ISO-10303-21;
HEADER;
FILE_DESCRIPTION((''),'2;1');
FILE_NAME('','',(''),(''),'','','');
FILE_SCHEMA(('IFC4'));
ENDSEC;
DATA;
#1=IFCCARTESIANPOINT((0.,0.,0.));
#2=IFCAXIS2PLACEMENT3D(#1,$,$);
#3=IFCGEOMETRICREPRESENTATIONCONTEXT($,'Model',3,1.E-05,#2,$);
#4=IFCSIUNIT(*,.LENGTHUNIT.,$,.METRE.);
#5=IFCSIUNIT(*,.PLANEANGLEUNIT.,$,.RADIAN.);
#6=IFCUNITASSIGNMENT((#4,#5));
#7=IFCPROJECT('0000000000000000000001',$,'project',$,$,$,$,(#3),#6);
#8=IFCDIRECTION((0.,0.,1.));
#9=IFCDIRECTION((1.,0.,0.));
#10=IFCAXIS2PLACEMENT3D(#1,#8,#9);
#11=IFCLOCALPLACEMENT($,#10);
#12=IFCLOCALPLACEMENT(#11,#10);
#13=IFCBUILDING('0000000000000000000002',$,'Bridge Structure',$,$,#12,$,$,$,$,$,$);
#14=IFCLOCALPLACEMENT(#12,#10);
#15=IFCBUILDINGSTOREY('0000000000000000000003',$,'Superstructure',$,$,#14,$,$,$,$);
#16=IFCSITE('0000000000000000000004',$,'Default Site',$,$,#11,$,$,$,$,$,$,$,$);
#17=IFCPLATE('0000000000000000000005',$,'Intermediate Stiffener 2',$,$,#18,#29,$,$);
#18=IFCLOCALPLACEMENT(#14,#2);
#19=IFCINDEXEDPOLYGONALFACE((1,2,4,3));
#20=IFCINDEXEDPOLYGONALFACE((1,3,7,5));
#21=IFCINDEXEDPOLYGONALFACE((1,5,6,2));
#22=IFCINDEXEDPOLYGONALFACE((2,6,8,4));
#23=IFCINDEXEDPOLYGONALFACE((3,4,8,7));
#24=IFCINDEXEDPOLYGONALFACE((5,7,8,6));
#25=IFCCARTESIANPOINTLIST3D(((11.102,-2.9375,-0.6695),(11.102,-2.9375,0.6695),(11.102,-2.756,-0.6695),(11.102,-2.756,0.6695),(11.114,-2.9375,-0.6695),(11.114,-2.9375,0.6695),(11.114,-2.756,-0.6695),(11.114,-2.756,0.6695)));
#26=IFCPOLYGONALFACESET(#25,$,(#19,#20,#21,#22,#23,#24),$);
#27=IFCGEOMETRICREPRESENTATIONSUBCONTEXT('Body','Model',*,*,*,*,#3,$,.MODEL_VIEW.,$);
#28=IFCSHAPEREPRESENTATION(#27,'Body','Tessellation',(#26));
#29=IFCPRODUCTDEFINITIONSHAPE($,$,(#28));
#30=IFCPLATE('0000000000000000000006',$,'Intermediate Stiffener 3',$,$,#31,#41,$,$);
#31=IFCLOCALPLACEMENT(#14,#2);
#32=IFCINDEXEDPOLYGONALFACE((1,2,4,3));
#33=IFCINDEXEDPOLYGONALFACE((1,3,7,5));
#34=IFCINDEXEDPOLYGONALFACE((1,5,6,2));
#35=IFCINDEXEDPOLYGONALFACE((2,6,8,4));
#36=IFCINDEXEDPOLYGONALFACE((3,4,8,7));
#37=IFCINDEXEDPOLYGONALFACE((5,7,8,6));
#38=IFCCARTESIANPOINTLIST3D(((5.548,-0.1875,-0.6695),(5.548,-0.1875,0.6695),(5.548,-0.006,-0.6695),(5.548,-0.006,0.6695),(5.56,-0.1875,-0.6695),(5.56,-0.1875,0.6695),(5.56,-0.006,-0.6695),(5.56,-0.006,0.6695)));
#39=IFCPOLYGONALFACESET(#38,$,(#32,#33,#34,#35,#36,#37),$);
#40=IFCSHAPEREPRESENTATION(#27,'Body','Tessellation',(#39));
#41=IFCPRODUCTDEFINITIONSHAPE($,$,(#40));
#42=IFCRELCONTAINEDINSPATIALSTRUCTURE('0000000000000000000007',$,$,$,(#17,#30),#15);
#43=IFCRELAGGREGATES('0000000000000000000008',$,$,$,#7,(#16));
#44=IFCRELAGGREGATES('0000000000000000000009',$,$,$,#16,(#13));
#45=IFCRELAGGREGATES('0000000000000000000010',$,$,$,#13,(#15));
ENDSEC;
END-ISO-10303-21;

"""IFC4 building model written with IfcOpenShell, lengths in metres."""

from ifc_helpers import new_model, si_unit, frame, origin, origin_with_axes, origin_2d_with_axis, place, context, subcontext, project, spatial, rectangle, extrude, element, save


model = new_model("IFC4")

# Units and contexts
model_context = context("Model", 3, precision=1e-05, world=origin())
body_context = subcontext(model_context, "Body", "Model", "MODEL_VIEW")
ifc_project = project(units=[si_unit("LENGTHUNIT", "METRE"), si_unit("PLANEANGLEUNIT", "RADIAN")], contexts=[model_context])

# Site, building, storey
site_placement = place(None, origin_with_axes())
site = spatial("IfcSite", under=ifc_project, at=site_placement, Name="Default Site")
building_placement = place(site_placement, origin_with_axes())
building = spatial("IfcBuilding", under=site, at=building_placement, Name="Bridge Structure")
storey_placement = place(building_placement, origin_with_axes())
storey = spatial("IfcBuildingStorey", under=building, at=storey_placement, Name="Superstructure")

# Plates
for number, where, z_axis, x_axis, name in (
    (1, (11.108, -2.8468, -0.6695), (0.0, 0.0, 1.0), (1.0, 0.0, 0.0), "Intermediate Stiffener 2"),
    (2, (5.554, -0.0968, -0.6695), (0.0, 0.0, 1.0), (1.0, 0.0, 0.0), "Intermediate Stiffener 3"),
):
    element("IfcPlate", number, at=place(storey_placement, frame(where, z_axis=z_axis, x_axis=x_axis)), inside=storey, Name=name, context=body_context, shape_type="SweptSolid", body=[
        extrude(rectangle(XDim=0.012, YDim=0.1815, at=origin_2d_with_axis()), origin_with_axes(), (0.0, 0.0, 1.0), 1.339),
    ])

save(model, "model.ifc")
